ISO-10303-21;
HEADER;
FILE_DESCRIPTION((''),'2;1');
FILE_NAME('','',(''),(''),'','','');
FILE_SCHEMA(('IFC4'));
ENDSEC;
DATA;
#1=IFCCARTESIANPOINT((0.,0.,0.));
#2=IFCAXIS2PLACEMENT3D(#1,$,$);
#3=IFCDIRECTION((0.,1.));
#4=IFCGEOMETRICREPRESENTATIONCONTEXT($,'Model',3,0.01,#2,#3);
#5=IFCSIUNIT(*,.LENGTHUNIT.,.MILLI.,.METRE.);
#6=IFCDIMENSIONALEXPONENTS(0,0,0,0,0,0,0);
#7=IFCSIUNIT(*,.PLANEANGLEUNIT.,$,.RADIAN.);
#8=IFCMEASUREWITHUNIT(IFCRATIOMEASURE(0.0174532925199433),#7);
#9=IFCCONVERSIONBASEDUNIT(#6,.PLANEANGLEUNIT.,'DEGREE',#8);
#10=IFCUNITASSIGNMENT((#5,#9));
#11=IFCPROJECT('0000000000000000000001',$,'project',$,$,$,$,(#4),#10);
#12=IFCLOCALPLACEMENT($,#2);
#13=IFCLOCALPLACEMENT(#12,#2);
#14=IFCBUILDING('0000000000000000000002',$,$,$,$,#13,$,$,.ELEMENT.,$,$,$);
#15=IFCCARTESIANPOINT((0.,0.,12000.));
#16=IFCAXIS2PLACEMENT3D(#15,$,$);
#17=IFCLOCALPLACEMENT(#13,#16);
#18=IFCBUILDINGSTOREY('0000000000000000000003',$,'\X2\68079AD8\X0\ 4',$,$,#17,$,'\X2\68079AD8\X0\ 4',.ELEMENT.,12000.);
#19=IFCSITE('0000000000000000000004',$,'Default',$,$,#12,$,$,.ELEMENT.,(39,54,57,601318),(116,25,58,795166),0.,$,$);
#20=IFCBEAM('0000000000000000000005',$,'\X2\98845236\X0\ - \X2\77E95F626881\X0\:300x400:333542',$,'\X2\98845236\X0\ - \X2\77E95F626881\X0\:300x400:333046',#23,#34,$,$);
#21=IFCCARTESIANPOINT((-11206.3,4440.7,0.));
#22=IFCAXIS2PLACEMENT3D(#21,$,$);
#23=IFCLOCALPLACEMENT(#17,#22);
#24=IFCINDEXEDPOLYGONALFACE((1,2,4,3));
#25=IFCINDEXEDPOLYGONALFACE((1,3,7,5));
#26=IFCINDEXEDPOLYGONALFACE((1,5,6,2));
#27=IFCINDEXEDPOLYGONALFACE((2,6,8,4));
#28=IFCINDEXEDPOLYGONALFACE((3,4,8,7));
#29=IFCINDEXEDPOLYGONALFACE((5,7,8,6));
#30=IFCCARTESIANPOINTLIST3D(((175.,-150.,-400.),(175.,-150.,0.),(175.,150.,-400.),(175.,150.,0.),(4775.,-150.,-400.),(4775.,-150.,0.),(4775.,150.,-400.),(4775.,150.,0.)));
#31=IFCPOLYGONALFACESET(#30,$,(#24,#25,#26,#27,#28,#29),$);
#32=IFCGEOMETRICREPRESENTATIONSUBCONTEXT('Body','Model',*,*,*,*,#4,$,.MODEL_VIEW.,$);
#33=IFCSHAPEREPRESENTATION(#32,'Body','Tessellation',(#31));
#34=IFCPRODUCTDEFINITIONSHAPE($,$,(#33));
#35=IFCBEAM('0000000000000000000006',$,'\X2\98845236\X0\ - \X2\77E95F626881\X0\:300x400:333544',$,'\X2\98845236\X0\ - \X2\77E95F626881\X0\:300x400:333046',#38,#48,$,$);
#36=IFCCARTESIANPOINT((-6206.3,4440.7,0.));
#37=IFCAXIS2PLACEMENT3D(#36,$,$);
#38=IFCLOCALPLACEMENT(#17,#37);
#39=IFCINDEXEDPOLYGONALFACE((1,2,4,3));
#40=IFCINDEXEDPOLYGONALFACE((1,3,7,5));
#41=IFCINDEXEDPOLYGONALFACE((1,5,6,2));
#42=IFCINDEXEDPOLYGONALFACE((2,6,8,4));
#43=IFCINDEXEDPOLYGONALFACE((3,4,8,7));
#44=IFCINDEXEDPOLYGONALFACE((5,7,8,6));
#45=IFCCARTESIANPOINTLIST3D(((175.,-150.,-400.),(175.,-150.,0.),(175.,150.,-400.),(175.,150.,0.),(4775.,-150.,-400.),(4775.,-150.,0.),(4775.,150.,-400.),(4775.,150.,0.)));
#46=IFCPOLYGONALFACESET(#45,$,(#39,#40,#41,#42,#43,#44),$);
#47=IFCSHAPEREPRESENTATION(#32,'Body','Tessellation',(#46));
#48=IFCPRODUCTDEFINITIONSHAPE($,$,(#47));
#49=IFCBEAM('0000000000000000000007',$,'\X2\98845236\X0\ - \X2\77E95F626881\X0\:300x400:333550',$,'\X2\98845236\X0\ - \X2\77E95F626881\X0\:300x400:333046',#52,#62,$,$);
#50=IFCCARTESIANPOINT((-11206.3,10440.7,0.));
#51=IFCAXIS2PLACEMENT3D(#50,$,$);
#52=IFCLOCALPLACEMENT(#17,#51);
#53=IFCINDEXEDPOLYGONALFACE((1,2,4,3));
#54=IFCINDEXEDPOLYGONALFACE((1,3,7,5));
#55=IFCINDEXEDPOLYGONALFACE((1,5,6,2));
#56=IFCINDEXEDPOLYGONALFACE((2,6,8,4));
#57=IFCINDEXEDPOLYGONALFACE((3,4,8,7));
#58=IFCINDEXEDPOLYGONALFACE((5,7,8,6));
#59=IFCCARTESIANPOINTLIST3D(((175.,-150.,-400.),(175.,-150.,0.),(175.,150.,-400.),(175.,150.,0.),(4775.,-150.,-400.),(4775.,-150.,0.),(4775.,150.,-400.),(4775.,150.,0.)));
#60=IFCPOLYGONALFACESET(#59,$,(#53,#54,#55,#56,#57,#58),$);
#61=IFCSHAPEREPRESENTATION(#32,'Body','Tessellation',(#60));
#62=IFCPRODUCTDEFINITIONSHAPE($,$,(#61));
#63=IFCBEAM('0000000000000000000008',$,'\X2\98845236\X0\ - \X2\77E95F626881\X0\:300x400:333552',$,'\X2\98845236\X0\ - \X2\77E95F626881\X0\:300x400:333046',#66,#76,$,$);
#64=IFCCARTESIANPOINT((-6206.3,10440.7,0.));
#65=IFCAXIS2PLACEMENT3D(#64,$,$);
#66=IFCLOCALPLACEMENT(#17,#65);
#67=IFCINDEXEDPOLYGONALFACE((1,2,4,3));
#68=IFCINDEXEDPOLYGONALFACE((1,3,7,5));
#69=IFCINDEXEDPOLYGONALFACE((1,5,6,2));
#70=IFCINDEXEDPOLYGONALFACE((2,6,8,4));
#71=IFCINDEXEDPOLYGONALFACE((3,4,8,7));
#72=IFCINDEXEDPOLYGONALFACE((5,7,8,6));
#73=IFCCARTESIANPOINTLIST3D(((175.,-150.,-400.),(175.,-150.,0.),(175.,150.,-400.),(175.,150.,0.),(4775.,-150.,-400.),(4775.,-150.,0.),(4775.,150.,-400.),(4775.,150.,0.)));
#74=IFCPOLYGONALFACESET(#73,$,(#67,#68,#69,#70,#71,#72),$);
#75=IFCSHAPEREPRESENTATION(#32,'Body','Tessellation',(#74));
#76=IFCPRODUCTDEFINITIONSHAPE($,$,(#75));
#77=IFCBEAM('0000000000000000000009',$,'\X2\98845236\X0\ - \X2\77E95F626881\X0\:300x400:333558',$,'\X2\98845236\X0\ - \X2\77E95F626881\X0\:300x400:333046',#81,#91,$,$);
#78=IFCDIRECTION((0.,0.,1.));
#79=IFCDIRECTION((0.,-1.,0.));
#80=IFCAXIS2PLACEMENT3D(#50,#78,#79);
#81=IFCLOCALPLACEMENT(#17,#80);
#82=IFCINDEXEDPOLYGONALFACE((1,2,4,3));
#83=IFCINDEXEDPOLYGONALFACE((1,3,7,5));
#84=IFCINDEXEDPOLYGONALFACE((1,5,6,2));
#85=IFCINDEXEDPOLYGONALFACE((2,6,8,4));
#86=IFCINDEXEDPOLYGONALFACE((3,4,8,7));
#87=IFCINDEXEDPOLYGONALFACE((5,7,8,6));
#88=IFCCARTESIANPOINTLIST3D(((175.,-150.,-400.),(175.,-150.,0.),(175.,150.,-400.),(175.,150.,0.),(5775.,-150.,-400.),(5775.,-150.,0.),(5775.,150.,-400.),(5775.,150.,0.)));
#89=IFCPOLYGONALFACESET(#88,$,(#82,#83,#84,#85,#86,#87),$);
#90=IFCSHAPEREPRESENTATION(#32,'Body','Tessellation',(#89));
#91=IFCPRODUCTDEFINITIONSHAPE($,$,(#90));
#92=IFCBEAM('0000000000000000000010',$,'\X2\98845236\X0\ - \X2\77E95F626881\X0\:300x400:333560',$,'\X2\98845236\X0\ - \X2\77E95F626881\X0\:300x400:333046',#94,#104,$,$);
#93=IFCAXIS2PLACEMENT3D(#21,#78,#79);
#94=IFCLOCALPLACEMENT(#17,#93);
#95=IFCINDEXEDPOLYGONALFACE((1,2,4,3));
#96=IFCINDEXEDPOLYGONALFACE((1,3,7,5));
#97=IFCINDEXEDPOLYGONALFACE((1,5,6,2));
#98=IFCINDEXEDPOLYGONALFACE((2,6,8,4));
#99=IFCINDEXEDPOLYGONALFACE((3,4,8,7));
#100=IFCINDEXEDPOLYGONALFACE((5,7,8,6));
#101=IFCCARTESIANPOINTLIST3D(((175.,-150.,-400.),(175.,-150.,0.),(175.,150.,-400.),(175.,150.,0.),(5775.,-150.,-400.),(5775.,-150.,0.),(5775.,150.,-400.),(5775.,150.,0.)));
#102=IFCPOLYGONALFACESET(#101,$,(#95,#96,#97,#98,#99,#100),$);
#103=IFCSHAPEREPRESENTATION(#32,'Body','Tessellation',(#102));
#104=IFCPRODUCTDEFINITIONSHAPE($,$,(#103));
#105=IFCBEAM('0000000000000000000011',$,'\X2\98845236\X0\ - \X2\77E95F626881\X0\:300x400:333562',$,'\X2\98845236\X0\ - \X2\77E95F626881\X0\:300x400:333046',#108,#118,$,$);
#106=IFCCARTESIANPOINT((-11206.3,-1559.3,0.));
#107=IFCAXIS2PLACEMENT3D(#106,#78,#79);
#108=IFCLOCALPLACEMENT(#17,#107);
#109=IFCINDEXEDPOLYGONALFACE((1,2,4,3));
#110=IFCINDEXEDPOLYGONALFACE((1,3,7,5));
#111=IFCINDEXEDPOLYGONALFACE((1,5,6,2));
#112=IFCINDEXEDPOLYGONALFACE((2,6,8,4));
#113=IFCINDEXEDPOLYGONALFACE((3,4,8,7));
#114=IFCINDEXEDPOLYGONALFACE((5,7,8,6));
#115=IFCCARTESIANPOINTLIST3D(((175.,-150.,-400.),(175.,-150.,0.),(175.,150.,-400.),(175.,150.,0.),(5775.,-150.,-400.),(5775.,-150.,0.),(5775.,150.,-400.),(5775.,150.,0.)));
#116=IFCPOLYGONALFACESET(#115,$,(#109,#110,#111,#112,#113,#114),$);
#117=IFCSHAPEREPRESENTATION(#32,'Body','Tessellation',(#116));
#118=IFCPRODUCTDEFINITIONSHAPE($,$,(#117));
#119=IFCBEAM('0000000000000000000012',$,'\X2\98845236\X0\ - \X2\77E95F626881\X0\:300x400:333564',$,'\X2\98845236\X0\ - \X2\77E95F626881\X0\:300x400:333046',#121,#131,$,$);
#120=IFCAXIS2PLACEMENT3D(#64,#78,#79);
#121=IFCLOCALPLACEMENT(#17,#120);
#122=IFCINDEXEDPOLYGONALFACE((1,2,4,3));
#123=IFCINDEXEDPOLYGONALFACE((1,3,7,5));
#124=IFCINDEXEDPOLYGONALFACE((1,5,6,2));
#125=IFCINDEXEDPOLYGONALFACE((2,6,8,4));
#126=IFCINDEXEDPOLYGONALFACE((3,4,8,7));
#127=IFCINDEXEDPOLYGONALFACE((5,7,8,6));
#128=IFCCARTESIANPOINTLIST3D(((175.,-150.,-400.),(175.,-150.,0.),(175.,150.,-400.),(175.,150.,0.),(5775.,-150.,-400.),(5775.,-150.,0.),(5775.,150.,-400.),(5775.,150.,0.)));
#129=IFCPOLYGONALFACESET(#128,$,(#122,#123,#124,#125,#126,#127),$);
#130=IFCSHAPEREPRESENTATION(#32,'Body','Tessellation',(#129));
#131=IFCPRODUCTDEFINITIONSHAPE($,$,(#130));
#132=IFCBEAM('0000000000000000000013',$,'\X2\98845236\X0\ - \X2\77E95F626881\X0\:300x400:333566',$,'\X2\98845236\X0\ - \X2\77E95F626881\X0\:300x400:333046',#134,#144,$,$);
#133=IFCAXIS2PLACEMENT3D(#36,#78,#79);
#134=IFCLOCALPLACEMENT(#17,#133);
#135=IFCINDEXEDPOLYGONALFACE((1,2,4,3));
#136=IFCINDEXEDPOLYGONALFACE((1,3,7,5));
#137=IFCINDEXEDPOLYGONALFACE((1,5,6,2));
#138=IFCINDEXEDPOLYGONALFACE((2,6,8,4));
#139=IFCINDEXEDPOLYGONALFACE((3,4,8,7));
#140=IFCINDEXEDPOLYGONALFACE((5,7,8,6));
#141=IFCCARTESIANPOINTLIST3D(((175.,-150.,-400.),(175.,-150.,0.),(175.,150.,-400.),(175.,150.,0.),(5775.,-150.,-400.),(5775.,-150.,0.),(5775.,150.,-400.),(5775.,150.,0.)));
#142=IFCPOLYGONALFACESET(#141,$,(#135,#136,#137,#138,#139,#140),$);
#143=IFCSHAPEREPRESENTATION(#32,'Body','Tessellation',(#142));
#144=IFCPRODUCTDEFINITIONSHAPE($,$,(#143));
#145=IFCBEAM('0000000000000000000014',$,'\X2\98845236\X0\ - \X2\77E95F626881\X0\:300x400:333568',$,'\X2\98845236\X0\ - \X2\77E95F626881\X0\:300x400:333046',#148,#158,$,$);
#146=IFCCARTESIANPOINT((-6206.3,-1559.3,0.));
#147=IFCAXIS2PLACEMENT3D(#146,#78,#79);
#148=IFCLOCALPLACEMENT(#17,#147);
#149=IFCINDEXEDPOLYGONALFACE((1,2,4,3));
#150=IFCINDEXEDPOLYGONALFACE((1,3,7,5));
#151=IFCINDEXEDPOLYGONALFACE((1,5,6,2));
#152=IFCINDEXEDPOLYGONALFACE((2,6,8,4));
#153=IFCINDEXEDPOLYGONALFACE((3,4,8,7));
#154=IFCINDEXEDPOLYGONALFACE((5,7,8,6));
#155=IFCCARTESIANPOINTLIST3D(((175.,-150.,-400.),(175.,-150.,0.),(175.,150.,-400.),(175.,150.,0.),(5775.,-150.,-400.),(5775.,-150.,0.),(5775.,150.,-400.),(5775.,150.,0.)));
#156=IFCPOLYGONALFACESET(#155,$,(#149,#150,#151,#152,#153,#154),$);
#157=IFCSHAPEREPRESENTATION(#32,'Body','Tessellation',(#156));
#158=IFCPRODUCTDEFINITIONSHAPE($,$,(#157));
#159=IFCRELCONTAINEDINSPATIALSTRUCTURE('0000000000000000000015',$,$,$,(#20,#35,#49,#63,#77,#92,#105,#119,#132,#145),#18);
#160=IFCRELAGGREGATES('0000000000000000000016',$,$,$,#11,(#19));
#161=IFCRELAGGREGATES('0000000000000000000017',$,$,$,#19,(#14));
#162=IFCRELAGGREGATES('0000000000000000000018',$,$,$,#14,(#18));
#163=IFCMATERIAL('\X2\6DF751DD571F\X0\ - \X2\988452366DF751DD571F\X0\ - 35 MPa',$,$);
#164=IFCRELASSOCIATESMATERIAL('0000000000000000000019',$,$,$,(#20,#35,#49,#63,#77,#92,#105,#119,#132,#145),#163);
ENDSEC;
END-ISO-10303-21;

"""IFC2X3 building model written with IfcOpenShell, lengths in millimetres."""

from ifc_helpers import new_model, entity, si_unit, converted_unit, direction, frame, frame_2d, origin, origin_2d_with_axis, place, context, subcontext, project, spatial, rectangle, extrude, material, element, save


model = new_model("IFC2X3")

# Units and contexts
model_context = context("Model", 3, precision=0.01, world=origin(), true_north=direction((0.0, 1.0)))
body_context = subcontext(model_context, "Body", "Model", "MODEL_VIEW")
ifc_project = project(units=[si_unit("LENGTHUNIT", "METRE", prefix="MILLI"), converted_unit("PLANEANGLEUNIT", "DEGREE", entity("IfcRatioMeasure", 0.0174532925199433), si_unit("PLANEANGLEUNIT", "RADIAN"), dimensions=[0, 0, 0, 0, 0, 0, 0])], contexts=[model_context])

# Site, building, storey
site_placement = place(None, origin())
site = spatial("IfcSite", under=ifc_project, at=site_placement, Name="Default", CompositionType="ELEMENT", RefLatitude=(39, 54, 57, 601318), RefLongitude=(116, 25, 58, 795166), RefElevation=0.0)
building_placement = place(site_placement, origin())
building = spatial("IfcBuilding", under=site, at=building_placement, CompositionType="ELEMENT")
storey_placement = place(building_placement, frame((0.0, 0.0, 12000.0)))
storey = spatial("IfcBuildingStorey", under=building, at=storey_placement, Name="标高 4", LongName="标高 4", CompositionType="ELEMENT", Elevation=12000.0)

# Shared definitions
ifc_material = material(Name="混凝土 - 预制混凝土 - 35 MPa")

# Beams
beam_1_placement = place(storey_placement, frame((-11206.3, 4440.7, 0.0)))
element("IfcBeam", 1, at=beam_1_placement, inside=storey, material=ifc_material, Name="预制 - 矩形梁:300x400:333542", ObjectType="预制 - 矩形梁:300x400:333046", context=body_context, shape_type="SweptSolid", body=[
    extrude(rectangle(XDim=400.0, YDim=300.0, at=frame_2d((0.0, 0.0), x_axis=(1.0, 0.0))), frame((175.0, 0.0, -200.0), z_axis=(1.0, 0.0, 0.0), x_axis=(0.0, 0.0, -1.0)), (0.0, 0.0, 1.0), 4600.0),
])
beam_2_placement = place(storey_placement, frame((-6206.3, 4440.7, 0.0)))
element("IfcBeam", 2, at=beam_2_placement, inside=storey, material=ifc_material, Name="预制 - 矩形梁:300x400:333544", ObjectType="预制 - 矩形梁:300x400:333046", context=body_context, shape_type="SweptSolid", body=[
    extrude(rectangle(XDim=400.0, YDim=300.0, at=frame_2d((0.0, 0.0), x_axis=(1.0, 0.0))), frame((175.0, 0.0, -200.0), z_axis=(1.0, 0.0, 0.0), x_axis=(0.0, 0.0, -1.0)), (0.0, 0.0, 1.0), 4600.0),
])
beam_3_placement = place(storey_placement, frame((-11206.3, 10440.7, 0.0)))
element("IfcBeam", 3, at=beam_3_placement, inside=storey, material=ifc_material, Name="预制 - 矩形梁:300x400:333550", ObjectType="预制 - 矩形梁:300x400:333046", context=body_context, shape_type="SweptSolid", body=[
    extrude(rectangle(XDim=400.0, YDim=300.0, at=frame_2d((0.0, 0.0), x_axis=(1.0, 0.0))), frame((175.0, 0.0, -200.0), z_axis=(1.0, 0.0, 0.0), x_axis=(0.0, 0.0, -1.0)), (0.0, 0.0, 1.0), 4600.0),
])
beam_4_placement = place(storey_placement, frame((-6206.3, 10440.7, 0.0)))
element("IfcBeam", 4, at=beam_4_placement, inside=storey, material=ifc_material, Name="预制 - 矩形梁:300x400:333552", ObjectType="预制 - 矩形梁:300x400:333046", context=body_context, shape_type="SweptSolid", body=[
    extrude(rectangle(XDim=400.0, YDim=300.0, at=frame_2d((0.0, 0.0), x_axis=(1.0, 0.0))), frame((175.0, 0.0, -200.0), z_axis=(1.0, 0.0, 0.0), x_axis=(0.0, 0.0, -1.0)), (0.0, 0.0, 1.0), 4600.0),
])
for number, where, z_axis, x_axis, name in (
    (5, (-11206.3, 10440.7, 0.0), (0.0, 0.0, 1.0), (0.0, -1.0, 0.0), "预制 - 矩形梁:300x400:333558"),
    (6, (-11206.3, 4440.7, 0.0), (0.0, 0.0, 1.0), (0.0, -1.0, 0.0), "预制 - 矩形梁:300x400:333560"),
):
    element("IfcBeam", number, at=place(storey_placement, frame(where, z_axis=z_axis, x_axis=x_axis)), inside=storey, material=ifc_material, Name=name, ObjectType="预制 - 矩形梁:300x400:333046", context=body_context, shape_type="SweptSolid", body=[
        extrude(rectangle(XDim=400.0, YDim=300.0, at=origin_2d_with_axis()), frame((175.0, 0.0, -200.0), z_axis=(1.0, 0.0, 0.0), x_axis=(0.0, 0.0, -1.0)), (0.0, 0.0, 1.0), 5600.0),
    ])
beam_5_placement = place(storey_placement, frame((-11206.3, -1559.3, 0.0), z_axis=(0.0, 0.0, 1.0), x_axis=(0.0, -1.0, 0.0)))
element("IfcBeam", 7, at=beam_5_placement, inside=storey, material=ifc_material, Name="预制 - 矩形梁:300x400:333562", ObjectType="预制 - 矩形梁:300x400:333046", context=body_context, shape_type="SweptSolid", body=[
    extrude(rectangle(XDim=400.0, YDim=300.0, at=frame_2d((0.0, 0.0), x_axis=(1.0, 0.0))), frame((175.0, 0.0, -200.0), z_axis=(1.0, 0.0, 0.0), x_axis=(0.0, 0.0, -1.0)), (0.0, 0.0, 1.0), 5600.0),
])
for number, where, z_axis, x_axis, name in (
    (8, (-6206.3, 10440.7, 0.0), (0.0, 0.0, 1.0), (0.0, -1.0, 0.0), "预制 - 矩形梁:300x400:333564"),
    (9, (-6206.3, 4440.7, 0.0), (0.0, 0.0, 1.0), (0.0, -1.0, 0.0), "预制 - 矩形梁:300x400:333566"),
    (10, (-6206.3, -1559.3, 0.0), (0.0, 0.0, 1.0), (0.0, -1.0, 0.0), "预制 - 矩形梁:300x400:333568"),
):
    element("IfcBeam", number, at=place(storey_placement, frame(where, z_axis=z_axis, x_axis=x_axis)), inside=storey, material=ifc_material, Name=name, ObjectType="预制 - 矩形梁:300x400:333046", context=body_context, shape_type="SweptSolid", body=[
        extrude(rectangle(XDim=400.0, YDim=300.0, at=origin_2d_with_axis()), frame((175.0, 0.0, -200.0), z_axis=(1.0, 0.0, 0.0), x_axis=(0.0, 0.0, -1.0)), (0.0, 0.0, 1.0), 5600.0),
    ])

save(model, "model.ifc")
